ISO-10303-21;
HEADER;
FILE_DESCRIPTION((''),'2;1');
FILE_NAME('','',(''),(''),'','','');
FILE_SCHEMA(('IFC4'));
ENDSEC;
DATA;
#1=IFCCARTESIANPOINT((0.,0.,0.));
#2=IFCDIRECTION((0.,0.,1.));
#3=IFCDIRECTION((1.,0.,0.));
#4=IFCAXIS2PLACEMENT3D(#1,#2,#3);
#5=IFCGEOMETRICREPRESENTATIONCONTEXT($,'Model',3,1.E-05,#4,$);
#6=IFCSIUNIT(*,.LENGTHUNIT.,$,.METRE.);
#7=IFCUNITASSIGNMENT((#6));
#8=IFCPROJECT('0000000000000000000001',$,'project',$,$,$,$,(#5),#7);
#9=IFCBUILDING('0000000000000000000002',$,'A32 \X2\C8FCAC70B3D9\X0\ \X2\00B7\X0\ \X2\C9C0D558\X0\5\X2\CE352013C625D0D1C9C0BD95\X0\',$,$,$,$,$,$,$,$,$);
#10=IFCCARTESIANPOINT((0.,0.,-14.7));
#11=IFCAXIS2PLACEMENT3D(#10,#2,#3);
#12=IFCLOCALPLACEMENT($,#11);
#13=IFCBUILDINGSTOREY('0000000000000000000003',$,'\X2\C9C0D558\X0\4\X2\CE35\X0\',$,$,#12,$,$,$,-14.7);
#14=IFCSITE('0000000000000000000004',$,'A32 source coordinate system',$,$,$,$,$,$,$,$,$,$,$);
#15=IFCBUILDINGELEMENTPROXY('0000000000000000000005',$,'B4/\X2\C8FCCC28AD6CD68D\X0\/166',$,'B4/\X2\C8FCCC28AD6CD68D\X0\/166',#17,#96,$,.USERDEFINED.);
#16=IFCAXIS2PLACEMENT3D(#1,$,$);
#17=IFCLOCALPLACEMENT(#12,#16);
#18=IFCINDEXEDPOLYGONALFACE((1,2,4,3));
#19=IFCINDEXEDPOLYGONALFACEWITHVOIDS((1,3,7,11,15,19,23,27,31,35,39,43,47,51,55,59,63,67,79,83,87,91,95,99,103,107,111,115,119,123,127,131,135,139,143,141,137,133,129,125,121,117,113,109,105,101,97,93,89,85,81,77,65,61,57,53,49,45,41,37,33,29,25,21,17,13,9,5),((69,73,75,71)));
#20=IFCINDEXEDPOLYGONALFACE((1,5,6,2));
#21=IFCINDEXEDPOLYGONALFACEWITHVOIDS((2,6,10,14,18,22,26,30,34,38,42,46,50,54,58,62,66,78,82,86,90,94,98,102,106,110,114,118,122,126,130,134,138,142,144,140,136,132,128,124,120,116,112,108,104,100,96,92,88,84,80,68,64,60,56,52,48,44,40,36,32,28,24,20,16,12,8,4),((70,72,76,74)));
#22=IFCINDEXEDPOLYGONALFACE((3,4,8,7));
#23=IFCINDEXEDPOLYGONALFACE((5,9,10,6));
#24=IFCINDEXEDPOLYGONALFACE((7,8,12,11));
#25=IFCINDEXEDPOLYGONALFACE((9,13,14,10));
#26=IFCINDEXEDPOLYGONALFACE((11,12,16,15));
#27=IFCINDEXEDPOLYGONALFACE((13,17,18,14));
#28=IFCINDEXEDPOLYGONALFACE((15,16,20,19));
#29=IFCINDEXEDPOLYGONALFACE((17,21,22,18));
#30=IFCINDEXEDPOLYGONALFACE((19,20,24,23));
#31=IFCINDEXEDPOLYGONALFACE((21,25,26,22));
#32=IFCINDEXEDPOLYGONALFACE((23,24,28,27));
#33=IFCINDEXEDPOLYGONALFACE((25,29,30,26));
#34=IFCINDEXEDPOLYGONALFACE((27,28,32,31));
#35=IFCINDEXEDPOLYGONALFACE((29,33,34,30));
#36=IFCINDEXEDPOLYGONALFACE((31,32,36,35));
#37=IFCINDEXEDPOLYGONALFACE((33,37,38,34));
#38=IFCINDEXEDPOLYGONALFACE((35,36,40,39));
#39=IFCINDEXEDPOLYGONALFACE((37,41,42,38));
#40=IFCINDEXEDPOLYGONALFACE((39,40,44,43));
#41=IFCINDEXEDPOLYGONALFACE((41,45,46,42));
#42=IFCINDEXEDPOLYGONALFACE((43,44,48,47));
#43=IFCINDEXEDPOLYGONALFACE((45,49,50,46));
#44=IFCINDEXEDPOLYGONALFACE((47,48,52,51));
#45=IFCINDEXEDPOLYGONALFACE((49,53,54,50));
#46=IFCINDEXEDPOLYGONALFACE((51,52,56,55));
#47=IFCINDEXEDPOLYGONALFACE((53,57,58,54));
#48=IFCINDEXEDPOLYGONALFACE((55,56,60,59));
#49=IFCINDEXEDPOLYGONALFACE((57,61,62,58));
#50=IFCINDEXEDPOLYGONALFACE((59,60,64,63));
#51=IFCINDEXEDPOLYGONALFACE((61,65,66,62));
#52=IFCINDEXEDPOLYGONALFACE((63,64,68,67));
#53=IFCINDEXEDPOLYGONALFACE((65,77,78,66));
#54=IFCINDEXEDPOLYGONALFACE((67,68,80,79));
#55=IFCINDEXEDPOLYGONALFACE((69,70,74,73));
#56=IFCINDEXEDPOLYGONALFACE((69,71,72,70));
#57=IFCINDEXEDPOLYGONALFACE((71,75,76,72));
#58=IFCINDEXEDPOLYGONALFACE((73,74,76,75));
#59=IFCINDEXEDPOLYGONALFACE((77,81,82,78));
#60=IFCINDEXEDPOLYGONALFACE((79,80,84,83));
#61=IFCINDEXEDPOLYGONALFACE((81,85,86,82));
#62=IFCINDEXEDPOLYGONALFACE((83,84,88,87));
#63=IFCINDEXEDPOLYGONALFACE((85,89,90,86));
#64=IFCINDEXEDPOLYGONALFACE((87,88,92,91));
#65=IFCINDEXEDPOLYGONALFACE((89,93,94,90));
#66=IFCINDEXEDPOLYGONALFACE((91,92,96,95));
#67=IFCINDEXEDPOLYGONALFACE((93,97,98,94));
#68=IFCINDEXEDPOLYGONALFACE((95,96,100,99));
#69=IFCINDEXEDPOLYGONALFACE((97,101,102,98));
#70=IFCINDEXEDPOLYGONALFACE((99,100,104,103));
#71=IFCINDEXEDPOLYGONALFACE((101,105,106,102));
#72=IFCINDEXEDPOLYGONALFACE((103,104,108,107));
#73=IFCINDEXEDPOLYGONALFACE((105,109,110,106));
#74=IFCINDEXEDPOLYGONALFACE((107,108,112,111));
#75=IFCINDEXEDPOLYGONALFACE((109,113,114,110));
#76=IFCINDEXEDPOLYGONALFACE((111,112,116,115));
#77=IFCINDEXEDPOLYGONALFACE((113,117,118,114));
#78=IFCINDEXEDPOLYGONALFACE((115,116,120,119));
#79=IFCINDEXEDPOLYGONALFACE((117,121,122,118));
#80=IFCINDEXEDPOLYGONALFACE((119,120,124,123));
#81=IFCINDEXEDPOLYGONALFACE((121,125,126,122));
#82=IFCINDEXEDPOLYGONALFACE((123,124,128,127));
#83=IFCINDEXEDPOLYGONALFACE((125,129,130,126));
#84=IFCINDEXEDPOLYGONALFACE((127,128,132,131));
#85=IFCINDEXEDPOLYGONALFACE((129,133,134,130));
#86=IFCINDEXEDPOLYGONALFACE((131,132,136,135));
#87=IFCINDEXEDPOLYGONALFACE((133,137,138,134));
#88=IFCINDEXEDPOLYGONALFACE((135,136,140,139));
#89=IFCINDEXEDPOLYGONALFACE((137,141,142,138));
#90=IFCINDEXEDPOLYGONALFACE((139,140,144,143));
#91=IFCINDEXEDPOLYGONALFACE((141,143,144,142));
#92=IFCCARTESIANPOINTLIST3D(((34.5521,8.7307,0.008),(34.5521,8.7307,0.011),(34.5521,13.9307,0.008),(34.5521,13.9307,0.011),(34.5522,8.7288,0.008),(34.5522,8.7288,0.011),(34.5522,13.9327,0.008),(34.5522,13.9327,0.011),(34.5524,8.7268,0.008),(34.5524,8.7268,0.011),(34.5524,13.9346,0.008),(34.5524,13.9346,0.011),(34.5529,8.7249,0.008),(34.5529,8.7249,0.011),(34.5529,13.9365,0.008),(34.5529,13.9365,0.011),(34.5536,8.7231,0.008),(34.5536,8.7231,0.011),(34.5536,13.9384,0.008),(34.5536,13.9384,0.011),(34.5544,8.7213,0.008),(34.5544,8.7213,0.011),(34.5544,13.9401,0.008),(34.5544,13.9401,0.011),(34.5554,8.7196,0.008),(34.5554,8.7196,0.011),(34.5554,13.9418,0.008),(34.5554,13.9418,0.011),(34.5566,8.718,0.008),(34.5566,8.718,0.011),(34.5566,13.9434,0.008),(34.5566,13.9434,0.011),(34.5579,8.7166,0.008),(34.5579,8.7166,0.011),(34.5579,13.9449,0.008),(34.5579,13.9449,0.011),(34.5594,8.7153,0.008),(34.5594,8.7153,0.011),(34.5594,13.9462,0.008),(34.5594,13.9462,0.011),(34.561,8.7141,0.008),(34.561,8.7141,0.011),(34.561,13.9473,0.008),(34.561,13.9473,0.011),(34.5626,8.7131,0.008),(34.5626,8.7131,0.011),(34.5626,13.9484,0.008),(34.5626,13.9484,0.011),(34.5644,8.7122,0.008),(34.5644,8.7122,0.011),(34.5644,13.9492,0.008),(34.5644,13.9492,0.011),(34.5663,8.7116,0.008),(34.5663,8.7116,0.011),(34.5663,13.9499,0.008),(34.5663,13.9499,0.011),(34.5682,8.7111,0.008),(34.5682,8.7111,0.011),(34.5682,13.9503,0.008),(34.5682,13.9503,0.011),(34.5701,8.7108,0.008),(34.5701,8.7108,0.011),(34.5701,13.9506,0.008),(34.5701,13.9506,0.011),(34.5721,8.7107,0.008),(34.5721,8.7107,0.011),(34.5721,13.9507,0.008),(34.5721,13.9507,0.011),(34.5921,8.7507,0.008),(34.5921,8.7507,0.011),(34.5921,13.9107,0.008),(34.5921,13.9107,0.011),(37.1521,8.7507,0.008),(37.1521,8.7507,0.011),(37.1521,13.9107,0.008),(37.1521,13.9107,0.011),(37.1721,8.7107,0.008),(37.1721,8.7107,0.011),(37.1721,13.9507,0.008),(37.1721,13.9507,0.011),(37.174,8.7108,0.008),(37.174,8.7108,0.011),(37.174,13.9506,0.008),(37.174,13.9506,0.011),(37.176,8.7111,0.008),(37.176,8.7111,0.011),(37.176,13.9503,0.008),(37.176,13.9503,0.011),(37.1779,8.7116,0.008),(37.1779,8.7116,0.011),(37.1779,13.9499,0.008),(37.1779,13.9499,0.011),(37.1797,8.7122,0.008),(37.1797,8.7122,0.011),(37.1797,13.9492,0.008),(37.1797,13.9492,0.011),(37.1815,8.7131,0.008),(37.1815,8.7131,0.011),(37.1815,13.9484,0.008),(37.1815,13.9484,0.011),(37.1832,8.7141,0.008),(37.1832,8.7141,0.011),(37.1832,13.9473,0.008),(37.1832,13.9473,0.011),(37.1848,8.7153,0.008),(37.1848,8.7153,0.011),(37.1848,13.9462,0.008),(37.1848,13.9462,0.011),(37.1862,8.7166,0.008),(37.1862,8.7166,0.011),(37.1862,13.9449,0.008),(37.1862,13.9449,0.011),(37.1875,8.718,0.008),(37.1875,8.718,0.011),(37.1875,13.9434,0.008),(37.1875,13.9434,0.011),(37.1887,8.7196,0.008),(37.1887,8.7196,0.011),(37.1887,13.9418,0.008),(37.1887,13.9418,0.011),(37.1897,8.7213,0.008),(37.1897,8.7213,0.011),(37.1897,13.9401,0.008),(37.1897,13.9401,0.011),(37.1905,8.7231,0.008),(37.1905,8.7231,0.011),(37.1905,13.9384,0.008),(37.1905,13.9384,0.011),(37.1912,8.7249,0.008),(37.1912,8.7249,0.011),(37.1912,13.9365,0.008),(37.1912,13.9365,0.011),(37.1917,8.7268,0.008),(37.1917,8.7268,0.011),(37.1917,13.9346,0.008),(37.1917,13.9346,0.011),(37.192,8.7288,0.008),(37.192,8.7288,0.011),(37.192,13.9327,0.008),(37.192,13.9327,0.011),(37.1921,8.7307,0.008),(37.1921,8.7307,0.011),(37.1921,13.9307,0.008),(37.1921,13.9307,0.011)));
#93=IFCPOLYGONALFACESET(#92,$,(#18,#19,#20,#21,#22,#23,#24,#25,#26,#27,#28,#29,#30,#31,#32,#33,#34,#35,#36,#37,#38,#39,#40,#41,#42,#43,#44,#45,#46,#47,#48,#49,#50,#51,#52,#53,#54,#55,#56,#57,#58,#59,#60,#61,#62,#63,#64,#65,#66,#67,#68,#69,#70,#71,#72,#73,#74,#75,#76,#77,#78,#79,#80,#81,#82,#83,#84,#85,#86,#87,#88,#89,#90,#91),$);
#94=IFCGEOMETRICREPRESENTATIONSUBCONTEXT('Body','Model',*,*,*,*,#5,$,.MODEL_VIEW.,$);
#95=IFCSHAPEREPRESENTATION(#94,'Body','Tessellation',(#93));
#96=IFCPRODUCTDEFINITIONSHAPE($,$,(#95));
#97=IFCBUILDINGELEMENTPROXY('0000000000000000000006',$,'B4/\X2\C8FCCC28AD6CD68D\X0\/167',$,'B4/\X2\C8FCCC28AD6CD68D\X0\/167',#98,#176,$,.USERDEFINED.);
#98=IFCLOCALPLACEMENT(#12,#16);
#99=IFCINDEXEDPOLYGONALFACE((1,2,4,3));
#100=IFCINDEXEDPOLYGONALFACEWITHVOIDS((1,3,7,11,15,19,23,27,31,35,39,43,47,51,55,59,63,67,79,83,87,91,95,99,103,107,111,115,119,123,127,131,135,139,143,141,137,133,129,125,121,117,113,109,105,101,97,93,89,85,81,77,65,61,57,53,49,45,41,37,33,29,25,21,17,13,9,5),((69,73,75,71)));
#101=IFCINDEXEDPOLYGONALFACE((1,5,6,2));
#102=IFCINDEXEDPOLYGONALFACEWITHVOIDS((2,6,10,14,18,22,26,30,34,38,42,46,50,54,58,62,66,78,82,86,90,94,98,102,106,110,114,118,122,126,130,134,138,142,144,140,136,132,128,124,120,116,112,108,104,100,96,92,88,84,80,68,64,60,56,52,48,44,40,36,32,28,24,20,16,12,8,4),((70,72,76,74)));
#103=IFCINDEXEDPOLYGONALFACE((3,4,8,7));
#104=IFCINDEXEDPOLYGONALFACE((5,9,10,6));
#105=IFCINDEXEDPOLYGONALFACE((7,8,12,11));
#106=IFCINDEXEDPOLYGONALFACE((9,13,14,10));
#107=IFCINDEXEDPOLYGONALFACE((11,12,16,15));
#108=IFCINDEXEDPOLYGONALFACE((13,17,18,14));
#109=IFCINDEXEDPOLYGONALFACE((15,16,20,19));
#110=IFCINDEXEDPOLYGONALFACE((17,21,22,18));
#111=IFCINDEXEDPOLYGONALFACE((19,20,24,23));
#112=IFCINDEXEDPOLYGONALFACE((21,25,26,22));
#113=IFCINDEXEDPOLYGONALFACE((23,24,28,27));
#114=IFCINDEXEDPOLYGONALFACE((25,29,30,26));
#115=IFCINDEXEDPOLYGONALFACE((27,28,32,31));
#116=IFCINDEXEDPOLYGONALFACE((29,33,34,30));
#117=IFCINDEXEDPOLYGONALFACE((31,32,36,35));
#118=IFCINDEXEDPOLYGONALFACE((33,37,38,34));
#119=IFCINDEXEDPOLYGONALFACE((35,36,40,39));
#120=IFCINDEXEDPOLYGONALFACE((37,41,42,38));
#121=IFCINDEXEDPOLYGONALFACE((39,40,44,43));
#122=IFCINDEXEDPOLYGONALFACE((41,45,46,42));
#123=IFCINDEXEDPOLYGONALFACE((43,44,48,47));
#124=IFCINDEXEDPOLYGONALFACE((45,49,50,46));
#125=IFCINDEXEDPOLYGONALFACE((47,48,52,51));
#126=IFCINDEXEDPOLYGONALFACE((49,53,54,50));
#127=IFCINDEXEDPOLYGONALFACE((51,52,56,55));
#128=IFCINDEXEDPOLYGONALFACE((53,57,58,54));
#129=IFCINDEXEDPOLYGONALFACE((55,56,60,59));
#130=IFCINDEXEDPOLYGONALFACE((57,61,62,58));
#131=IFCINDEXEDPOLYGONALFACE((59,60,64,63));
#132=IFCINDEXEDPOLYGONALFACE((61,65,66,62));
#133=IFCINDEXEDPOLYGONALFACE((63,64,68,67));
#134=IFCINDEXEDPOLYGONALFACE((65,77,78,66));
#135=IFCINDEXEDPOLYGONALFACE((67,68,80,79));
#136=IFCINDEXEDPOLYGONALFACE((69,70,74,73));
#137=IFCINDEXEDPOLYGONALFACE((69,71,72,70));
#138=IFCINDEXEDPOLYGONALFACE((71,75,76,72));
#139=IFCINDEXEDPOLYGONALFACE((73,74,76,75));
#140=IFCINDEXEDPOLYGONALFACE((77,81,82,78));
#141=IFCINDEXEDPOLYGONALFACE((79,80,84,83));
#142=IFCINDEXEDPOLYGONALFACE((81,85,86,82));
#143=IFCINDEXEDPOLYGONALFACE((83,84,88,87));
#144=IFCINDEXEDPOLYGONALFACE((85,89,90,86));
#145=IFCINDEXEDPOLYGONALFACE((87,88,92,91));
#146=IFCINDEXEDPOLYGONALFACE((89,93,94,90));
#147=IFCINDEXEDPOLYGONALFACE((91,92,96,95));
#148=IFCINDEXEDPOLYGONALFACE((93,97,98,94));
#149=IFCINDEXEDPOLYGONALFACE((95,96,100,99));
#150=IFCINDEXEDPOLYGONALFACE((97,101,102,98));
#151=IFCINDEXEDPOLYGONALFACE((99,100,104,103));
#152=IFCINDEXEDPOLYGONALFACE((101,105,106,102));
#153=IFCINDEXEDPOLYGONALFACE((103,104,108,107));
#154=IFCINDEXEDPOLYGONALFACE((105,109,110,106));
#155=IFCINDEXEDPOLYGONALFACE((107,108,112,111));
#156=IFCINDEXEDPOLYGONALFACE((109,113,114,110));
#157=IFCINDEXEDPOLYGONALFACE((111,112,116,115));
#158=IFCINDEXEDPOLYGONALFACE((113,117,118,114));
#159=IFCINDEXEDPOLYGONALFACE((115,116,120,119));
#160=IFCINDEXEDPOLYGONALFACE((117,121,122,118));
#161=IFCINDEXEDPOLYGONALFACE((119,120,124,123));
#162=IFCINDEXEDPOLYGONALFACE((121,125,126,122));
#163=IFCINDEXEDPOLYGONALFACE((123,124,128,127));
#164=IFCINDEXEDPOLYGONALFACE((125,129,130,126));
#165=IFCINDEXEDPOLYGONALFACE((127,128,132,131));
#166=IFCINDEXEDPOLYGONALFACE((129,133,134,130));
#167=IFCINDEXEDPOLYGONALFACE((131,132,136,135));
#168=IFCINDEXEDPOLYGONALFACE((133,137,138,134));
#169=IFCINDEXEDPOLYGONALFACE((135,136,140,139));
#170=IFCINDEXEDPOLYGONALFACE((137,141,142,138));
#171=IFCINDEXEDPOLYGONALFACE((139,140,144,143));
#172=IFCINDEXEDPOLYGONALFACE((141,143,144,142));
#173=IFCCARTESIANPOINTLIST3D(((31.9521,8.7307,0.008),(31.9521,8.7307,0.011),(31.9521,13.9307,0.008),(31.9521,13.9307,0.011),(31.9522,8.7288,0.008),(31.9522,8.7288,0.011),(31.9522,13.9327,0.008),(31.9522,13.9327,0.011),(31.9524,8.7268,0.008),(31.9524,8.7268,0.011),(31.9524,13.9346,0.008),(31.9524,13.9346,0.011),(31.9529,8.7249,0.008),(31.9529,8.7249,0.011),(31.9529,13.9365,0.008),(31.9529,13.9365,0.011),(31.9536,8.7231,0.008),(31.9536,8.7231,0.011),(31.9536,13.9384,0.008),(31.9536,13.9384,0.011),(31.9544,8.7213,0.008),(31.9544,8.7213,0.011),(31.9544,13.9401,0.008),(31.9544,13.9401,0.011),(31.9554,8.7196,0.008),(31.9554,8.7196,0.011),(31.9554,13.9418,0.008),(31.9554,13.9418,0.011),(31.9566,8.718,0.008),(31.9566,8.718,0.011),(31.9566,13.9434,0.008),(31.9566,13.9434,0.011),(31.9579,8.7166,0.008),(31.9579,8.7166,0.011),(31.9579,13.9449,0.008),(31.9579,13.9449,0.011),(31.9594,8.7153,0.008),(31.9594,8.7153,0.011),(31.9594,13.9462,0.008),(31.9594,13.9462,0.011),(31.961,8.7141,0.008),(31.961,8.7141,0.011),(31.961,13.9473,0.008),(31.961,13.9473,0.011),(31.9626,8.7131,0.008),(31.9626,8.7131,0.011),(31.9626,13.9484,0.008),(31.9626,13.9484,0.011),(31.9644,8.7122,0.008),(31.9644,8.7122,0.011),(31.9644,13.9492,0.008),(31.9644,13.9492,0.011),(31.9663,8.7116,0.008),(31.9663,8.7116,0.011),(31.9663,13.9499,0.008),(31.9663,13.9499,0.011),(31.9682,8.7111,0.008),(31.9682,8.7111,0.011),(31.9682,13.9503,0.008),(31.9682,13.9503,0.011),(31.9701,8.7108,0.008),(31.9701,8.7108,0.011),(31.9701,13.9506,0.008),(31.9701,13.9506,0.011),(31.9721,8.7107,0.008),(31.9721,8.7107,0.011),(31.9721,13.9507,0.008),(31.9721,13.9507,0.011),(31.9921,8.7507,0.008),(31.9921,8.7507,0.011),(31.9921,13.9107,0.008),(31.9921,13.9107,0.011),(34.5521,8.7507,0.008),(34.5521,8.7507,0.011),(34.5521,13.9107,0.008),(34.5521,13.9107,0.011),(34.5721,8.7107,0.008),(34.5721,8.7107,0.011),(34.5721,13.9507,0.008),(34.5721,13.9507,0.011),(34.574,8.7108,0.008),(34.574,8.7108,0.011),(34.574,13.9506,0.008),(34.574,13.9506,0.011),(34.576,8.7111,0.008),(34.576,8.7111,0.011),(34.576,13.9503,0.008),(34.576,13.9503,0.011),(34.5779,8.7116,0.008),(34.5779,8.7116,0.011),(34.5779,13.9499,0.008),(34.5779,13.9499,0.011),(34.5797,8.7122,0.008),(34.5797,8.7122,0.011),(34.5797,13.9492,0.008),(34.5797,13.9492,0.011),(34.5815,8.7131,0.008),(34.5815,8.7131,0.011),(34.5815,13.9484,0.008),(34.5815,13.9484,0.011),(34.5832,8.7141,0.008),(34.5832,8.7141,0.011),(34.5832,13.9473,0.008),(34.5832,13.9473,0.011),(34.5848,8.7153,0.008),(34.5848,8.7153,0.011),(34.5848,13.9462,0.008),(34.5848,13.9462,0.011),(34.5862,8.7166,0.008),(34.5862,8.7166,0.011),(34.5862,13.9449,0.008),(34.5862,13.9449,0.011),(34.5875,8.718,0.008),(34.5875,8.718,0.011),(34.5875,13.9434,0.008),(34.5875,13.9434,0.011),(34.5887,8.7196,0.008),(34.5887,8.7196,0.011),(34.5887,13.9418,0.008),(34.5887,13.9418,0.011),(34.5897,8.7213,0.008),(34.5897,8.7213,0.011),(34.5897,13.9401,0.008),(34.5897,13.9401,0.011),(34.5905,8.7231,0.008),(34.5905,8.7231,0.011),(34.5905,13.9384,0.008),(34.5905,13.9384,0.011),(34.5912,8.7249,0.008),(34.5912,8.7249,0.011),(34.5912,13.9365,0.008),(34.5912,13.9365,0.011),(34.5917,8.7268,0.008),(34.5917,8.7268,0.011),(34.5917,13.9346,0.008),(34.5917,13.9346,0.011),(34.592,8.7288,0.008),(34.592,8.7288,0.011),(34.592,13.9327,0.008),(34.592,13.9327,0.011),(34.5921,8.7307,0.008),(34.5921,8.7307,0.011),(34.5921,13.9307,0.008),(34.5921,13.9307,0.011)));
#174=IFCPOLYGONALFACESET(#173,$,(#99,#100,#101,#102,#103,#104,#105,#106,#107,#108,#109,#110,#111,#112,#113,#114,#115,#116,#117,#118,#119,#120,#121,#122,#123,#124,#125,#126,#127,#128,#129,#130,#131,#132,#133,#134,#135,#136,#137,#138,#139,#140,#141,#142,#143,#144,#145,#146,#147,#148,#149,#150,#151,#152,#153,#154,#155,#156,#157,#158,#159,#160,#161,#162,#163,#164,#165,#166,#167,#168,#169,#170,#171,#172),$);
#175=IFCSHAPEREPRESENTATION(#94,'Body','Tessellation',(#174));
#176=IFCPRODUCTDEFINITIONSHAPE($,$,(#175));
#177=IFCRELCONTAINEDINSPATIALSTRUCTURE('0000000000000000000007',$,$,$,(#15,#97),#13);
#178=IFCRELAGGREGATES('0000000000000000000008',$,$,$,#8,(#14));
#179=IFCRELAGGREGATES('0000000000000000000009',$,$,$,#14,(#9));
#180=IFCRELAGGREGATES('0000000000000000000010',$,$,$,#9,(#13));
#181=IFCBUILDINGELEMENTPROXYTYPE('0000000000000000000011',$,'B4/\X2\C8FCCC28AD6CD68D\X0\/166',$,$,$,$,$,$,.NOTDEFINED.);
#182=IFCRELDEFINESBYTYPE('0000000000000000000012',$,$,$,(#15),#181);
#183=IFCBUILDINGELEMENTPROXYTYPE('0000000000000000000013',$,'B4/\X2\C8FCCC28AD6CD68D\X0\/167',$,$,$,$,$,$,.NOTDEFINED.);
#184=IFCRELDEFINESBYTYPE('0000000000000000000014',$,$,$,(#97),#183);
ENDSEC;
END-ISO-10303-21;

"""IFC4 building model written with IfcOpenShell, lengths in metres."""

from ifc_helpers import new_model, si_unit, frame, origin, origin_with_axes, place, context, subcontext, project, spatial, polyline, outline, extrude, source, transform, mapped, type_object, type_shapes, element, save


model = new_model("IFC4")

# Units and contexts
model_context = context("Model", 3, precision=1e-05, world=origin_with_axes())
body_context = subcontext(model_context, "Body", "Model", "MODEL_VIEW")
ifc_project = project(units=[si_unit("LENGTHUNIT", "METRE")], contexts=[model_context])

# Site, building, storey
site = spatial("IfcSite", under=ifc_project, Name="A32 source coordinate system")
building = spatial("IfcBuilding", under=site, Name="A32 주거동 · 지하5층–옥탑지붕")
storey_placement = place(None, frame((0.0, 0.0, -14.7), z_axis=(0.0, 0.0, 1.0), x_axis=(1.0, 0.0, 0.0)))
storey = spatial("IfcBuildingStorey", under=building, at=storey_placement, Name="지하4층", Elevation=-14.7)

# Building element proxies
building_element_proxy_type_1 = type_object("IfcBuildingElementProxyType", Name="B4/주차구획/166", PredefinedType="NOTDEFINED")
shared_shape_1 = source(origin(), body_context, "Body", "SweptSolid", [
    extrude(outline(polyline([(37.1921, 8.7307), (37.192, 8.7288), (37.1917, 8.7268), (37.1912, 8.7249), (37.1905, 8.7231), (37.1897, 8.7213), (37.1887, 8.7196), (37.1875, 8.718), (37.1862, 8.7166), (37.1848, 8.7153), (37.1832, 8.7141), (37.1815, 8.7131), (37.1797, 8.7122), (37.1779, 8.7116), (37.176, 8.7111), (37.174, 8.7108), (37.1721, 8.7107), (34.5721, 8.7107), (34.5701, 8.7108), (34.5682, 8.7111), (34.5663, 8.7116), (34.5644, 8.7122), (34.5626, 8.7131), (34.561, 8.7141), (34.5594, 8.7153), (34.5579, 8.7166), (34.5566, 8.718), (34.5554, 8.7196), (34.5544, 8.7213), (34.5536, 8.7231), (34.5529, 8.7249), (34.5524, 8.7268), (34.5522, 8.7288), (34.5521, 8.7307), (34.5521, 13.9307), (34.5522, 13.9327), (34.5524, 13.9346), (34.5529, 13.9365), (34.5536, 13.9384), (34.5544, 13.9401), (34.5554, 13.9418), (34.5566, 13.9434), (34.5579, 13.9449), (34.5594, 13.9462), (34.561, 13.9473), (34.5626, 13.9484), (34.5644, 13.9492), (34.5663, 13.9499), (34.5682, 13.9503), (34.5701, 13.9506), (34.5721, 13.9507), (37.1721, 13.9507), (37.174, 13.9506), (37.176, 13.9503), (37.1779, 13.9499), (37.1797, 13.9492), (37.1815, 13.9484), (37.1832, 13.9473), (37.1848, 13.9462), (37.1862, 13.9449), (37.1875, 13.9434), (37.1887, 13.9418), (37.1897, 13.9401), (37.1905, 13.9384), (37.1912, 13.9365), (37.1917, 13.9346), (37.192, 13.9327), (37.1921, 13.9307), (37.1921, 8.7307)]), holes=[polyline([(37.1521, 8.7507), (37.1521, 13.9107), (34.5921, 13.9107), (34.5921, 8.7507), (37.1521, 8.7507)])]), frame((0.0, 0.0, 0.008)), (0.0, 0.0, 1.0), 0.003),
])
type_shapes(building_element_proxy_type_1, [shared_shape_1])
proxy_1_placement = place(storey_placement, origin_with_axes())
element("IfcBuildingElementProxy", 1, at=proxy_1_placement, inside=storey, type_object=building_element_proxy_type_1, Name="B4/주차구획/166", ObjectType="B4/주차구획/166", PredefinedType="USERDEFINED", context=body_context, shape_type="MappedRepresentation", body=[
    mapped(shared_shape_1, transform((0.0, 0.0, 0.0), scale=1.0)),
])
building_element_proxy_type_2 = type_object("IfcBuildingElementProxyType", Name="B4/주차구획/167", PredefinedType="NOTDEFINED")
shared_shape_2 = source(origin(), body_context, "Body", "SweptSolid", [
    extrude(outline(polyline([(34.5921, 8.7307), (34.592, 8.7288), (34.5917, 8.7268), (34.5912, 8.7249), (34.5905, 8.7231), (34.5897, 8.7213), (34.5887, 8.7196), (34.5875, 8.718), (34.5862, 8.7166), (34.5848, 8.7153), (34.5832, 8.7141), (34.5815, 8.7131), (34.5797, 8.7122), (34.5779, 8.7116), (34.576, 8.7111), (34.574, 8.7108), (34.5721, 8.7107), (31.9721, 8.7107), (31.9701, 8.7108), (31.9682, 8.7111), (31.9663, 8.7116), (31.9644, 8.7122), (31.9626, 8.7131), (31.961, 8.7141), (31.9594, 8.7153), (31.9579, 8.7166), (31.9566, 8.718), (31.9554, 8.7196), (31.9544, 8.7213), (31.9536, 8.7231), (31.9529, 8.7249), (31.9524, 8.7268), (31.9522, 8.7288), (31.9521, 8.7307), (31.9521, 13.9307), (31.9522, 13.9327), (31.9524, 13.9346), (31.9529, 13.9365), (31.9536, 13.9384), (31.9544, 13.9401), (31.9554, 13.9418), (31.9566, 13.9434), (31.9579, 13.9449), (31.9594, 13.9462), (31.961, 13.9473), (31.9626, 13.9484), (31.9644, 13.9492), (31.9663, 13.9499), (31.9682, 13.9503), (31.9701, 13.9506), (31.9721, 13.9507), (34.5721, 13.9507), (34.574, 13.9506), (34.576, 13.9503), (34.5779, 13.9499), (34.5797, 13.9492), (34.5815, 13.9484), (34.5832, 13.9473), (34.5848, 13.9462), (34.5862, 13.9449), (34.5875, 13.9434), (34.5887, 13.9418), (34.5897, 13.9401), (34.5905, 13.9384), (34.5912, 13.9365), (34.5917, 13.9346), (34.592, 13.9327), (34.5921, 13.9307), (34.5921, 8.7307)]), holes=[polyline([(34.5521, 8.7507), (34.5521, 13.9107), (31.9921, 13.9107), (31.9921, 8.7507), (34.5521, 8.7507)])]), frame((0.0, 0.0, 0.008)), (0.0, 0.0, 1.0), 0.003),
])
type_shapes(building_element_proxy_type_2, [shared_shape_2])
proxy_2_placement = place(storey_placement, origin_with_axes())
element("IfcBuildingElementProxy", 2, at=proxy_2_placement, inside=storey, type_object=building_element_proxy_type_2, Name="B4/주차구획/167", ObjectType="B4/주차구획/167", PredefinedType="USERDEFINED", context=body_context, shape_type="MappedRepresentation", body=[
    mapped(shared_shape_2, transform((0.0, 0.0, 0.0), scale=1.0)),
])

save(model, "model.ifc")
